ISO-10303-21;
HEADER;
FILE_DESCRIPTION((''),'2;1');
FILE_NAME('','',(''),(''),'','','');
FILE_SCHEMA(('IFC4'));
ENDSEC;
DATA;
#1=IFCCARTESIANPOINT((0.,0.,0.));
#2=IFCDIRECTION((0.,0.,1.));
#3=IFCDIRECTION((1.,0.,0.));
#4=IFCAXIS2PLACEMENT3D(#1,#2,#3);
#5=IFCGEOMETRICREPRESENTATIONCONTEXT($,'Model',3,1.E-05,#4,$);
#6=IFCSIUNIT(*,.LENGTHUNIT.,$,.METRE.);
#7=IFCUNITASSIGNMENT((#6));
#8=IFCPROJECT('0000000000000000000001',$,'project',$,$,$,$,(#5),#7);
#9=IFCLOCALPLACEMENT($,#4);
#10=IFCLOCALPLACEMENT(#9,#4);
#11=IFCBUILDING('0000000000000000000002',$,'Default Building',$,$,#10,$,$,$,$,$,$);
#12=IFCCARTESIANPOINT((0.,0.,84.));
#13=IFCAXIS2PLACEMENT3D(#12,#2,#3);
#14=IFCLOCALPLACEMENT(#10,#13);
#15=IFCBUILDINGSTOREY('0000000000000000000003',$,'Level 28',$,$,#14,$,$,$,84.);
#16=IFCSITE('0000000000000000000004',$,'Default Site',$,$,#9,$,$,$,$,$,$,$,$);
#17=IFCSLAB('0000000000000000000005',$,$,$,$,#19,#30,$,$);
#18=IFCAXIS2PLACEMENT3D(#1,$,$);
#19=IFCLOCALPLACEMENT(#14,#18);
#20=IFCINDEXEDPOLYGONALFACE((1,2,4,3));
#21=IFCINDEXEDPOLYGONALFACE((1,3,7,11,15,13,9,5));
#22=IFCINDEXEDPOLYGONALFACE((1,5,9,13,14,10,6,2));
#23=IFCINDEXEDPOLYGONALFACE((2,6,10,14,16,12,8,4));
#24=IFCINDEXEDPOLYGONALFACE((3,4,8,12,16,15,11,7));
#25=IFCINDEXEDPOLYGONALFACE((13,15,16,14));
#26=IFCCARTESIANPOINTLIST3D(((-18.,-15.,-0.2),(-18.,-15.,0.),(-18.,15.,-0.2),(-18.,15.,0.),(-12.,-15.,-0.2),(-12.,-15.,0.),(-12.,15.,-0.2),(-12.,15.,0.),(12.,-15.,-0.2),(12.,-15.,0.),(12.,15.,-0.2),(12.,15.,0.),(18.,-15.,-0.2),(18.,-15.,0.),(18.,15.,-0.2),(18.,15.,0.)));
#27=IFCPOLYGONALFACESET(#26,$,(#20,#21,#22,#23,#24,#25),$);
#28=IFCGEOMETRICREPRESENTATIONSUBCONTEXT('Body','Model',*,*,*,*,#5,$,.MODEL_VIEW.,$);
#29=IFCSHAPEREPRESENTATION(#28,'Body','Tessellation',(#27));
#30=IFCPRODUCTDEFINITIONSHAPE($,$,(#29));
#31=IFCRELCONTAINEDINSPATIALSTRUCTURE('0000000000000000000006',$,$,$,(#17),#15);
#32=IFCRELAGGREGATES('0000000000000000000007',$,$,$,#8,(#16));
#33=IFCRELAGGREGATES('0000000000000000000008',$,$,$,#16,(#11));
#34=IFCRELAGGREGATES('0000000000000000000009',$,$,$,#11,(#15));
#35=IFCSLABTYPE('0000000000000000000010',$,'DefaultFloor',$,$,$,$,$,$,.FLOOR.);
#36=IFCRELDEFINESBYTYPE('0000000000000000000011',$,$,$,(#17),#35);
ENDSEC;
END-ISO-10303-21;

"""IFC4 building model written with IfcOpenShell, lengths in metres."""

from ifc_helpers import new_model, si_unit, frame, origin_with_axes, place, context, subcontext, project, spatial, polyline, outline, extrude, type_object, element, save


model = new_model("IFC4")

# Units and contexts
model_context = context("Model", 3, precision=1e-05, world=origin_with_axes())
body_context = subcontext(model_context, "Body", "Model", "MODEL_VIEW")
ifc_project = project(units=[si_unit("LENGTHUNIT", "METRE")], contexts=[model_context])

# Site, building, storey
site_placement = place(None, origin_with_axes())
site = spatial("IfcSite", under=ifc_project, at=site_placement, Name="Default Site")
building_placement = place(site_placement, origin_with_axes())
building = spatial("IfcBuilding", under=site, at=building_placement, Name="Default Building")
storey_placement = place(building_placement, frame((0.0, 0.0, 84.0), z_axis=(0.0, 0.0, 1.0), x_axis=(1.0, 0.0, 0.0)))
storey = spatial("IfcBuildingStorey", under=building, at=storey_placement, Name="Level 28", Elevation=84.0)

# Slab
slab_type = type_object("IfcSlabType", Name="DefaultFloor", PredefinedType="FLOOR")
slab_placement = place(storey_placement, frame((0.0, 0.0, -84.0), z_axis=(0.0, 0.0, 1.0), x_axis=(1.0, 0.0, 0.0)))
element("IfcSlab", 1, at=slab_placement, inside=storey, type_object=slab_type, context=body_context, shape_type="SweptSolid", body=[
    extrude(outline(polyline([(-18.0, -15.0), (-18.0, 15.0), (-12.0, 15.0), (12.0, 15.0), (18.0, 15.0), (18.0, -15.0), (12.0, -15.0), (-12.0, -15.0), (-18.0, -15.0)])), frame((0.0, 0.0, 84.0), z_axis=(0.0, 0.0, 1.0), x_axis=(1.0, 0.0, 0.0)), (0.0, 0.0, -1.0), 0.2),
])

save(model, "model.ifc")
